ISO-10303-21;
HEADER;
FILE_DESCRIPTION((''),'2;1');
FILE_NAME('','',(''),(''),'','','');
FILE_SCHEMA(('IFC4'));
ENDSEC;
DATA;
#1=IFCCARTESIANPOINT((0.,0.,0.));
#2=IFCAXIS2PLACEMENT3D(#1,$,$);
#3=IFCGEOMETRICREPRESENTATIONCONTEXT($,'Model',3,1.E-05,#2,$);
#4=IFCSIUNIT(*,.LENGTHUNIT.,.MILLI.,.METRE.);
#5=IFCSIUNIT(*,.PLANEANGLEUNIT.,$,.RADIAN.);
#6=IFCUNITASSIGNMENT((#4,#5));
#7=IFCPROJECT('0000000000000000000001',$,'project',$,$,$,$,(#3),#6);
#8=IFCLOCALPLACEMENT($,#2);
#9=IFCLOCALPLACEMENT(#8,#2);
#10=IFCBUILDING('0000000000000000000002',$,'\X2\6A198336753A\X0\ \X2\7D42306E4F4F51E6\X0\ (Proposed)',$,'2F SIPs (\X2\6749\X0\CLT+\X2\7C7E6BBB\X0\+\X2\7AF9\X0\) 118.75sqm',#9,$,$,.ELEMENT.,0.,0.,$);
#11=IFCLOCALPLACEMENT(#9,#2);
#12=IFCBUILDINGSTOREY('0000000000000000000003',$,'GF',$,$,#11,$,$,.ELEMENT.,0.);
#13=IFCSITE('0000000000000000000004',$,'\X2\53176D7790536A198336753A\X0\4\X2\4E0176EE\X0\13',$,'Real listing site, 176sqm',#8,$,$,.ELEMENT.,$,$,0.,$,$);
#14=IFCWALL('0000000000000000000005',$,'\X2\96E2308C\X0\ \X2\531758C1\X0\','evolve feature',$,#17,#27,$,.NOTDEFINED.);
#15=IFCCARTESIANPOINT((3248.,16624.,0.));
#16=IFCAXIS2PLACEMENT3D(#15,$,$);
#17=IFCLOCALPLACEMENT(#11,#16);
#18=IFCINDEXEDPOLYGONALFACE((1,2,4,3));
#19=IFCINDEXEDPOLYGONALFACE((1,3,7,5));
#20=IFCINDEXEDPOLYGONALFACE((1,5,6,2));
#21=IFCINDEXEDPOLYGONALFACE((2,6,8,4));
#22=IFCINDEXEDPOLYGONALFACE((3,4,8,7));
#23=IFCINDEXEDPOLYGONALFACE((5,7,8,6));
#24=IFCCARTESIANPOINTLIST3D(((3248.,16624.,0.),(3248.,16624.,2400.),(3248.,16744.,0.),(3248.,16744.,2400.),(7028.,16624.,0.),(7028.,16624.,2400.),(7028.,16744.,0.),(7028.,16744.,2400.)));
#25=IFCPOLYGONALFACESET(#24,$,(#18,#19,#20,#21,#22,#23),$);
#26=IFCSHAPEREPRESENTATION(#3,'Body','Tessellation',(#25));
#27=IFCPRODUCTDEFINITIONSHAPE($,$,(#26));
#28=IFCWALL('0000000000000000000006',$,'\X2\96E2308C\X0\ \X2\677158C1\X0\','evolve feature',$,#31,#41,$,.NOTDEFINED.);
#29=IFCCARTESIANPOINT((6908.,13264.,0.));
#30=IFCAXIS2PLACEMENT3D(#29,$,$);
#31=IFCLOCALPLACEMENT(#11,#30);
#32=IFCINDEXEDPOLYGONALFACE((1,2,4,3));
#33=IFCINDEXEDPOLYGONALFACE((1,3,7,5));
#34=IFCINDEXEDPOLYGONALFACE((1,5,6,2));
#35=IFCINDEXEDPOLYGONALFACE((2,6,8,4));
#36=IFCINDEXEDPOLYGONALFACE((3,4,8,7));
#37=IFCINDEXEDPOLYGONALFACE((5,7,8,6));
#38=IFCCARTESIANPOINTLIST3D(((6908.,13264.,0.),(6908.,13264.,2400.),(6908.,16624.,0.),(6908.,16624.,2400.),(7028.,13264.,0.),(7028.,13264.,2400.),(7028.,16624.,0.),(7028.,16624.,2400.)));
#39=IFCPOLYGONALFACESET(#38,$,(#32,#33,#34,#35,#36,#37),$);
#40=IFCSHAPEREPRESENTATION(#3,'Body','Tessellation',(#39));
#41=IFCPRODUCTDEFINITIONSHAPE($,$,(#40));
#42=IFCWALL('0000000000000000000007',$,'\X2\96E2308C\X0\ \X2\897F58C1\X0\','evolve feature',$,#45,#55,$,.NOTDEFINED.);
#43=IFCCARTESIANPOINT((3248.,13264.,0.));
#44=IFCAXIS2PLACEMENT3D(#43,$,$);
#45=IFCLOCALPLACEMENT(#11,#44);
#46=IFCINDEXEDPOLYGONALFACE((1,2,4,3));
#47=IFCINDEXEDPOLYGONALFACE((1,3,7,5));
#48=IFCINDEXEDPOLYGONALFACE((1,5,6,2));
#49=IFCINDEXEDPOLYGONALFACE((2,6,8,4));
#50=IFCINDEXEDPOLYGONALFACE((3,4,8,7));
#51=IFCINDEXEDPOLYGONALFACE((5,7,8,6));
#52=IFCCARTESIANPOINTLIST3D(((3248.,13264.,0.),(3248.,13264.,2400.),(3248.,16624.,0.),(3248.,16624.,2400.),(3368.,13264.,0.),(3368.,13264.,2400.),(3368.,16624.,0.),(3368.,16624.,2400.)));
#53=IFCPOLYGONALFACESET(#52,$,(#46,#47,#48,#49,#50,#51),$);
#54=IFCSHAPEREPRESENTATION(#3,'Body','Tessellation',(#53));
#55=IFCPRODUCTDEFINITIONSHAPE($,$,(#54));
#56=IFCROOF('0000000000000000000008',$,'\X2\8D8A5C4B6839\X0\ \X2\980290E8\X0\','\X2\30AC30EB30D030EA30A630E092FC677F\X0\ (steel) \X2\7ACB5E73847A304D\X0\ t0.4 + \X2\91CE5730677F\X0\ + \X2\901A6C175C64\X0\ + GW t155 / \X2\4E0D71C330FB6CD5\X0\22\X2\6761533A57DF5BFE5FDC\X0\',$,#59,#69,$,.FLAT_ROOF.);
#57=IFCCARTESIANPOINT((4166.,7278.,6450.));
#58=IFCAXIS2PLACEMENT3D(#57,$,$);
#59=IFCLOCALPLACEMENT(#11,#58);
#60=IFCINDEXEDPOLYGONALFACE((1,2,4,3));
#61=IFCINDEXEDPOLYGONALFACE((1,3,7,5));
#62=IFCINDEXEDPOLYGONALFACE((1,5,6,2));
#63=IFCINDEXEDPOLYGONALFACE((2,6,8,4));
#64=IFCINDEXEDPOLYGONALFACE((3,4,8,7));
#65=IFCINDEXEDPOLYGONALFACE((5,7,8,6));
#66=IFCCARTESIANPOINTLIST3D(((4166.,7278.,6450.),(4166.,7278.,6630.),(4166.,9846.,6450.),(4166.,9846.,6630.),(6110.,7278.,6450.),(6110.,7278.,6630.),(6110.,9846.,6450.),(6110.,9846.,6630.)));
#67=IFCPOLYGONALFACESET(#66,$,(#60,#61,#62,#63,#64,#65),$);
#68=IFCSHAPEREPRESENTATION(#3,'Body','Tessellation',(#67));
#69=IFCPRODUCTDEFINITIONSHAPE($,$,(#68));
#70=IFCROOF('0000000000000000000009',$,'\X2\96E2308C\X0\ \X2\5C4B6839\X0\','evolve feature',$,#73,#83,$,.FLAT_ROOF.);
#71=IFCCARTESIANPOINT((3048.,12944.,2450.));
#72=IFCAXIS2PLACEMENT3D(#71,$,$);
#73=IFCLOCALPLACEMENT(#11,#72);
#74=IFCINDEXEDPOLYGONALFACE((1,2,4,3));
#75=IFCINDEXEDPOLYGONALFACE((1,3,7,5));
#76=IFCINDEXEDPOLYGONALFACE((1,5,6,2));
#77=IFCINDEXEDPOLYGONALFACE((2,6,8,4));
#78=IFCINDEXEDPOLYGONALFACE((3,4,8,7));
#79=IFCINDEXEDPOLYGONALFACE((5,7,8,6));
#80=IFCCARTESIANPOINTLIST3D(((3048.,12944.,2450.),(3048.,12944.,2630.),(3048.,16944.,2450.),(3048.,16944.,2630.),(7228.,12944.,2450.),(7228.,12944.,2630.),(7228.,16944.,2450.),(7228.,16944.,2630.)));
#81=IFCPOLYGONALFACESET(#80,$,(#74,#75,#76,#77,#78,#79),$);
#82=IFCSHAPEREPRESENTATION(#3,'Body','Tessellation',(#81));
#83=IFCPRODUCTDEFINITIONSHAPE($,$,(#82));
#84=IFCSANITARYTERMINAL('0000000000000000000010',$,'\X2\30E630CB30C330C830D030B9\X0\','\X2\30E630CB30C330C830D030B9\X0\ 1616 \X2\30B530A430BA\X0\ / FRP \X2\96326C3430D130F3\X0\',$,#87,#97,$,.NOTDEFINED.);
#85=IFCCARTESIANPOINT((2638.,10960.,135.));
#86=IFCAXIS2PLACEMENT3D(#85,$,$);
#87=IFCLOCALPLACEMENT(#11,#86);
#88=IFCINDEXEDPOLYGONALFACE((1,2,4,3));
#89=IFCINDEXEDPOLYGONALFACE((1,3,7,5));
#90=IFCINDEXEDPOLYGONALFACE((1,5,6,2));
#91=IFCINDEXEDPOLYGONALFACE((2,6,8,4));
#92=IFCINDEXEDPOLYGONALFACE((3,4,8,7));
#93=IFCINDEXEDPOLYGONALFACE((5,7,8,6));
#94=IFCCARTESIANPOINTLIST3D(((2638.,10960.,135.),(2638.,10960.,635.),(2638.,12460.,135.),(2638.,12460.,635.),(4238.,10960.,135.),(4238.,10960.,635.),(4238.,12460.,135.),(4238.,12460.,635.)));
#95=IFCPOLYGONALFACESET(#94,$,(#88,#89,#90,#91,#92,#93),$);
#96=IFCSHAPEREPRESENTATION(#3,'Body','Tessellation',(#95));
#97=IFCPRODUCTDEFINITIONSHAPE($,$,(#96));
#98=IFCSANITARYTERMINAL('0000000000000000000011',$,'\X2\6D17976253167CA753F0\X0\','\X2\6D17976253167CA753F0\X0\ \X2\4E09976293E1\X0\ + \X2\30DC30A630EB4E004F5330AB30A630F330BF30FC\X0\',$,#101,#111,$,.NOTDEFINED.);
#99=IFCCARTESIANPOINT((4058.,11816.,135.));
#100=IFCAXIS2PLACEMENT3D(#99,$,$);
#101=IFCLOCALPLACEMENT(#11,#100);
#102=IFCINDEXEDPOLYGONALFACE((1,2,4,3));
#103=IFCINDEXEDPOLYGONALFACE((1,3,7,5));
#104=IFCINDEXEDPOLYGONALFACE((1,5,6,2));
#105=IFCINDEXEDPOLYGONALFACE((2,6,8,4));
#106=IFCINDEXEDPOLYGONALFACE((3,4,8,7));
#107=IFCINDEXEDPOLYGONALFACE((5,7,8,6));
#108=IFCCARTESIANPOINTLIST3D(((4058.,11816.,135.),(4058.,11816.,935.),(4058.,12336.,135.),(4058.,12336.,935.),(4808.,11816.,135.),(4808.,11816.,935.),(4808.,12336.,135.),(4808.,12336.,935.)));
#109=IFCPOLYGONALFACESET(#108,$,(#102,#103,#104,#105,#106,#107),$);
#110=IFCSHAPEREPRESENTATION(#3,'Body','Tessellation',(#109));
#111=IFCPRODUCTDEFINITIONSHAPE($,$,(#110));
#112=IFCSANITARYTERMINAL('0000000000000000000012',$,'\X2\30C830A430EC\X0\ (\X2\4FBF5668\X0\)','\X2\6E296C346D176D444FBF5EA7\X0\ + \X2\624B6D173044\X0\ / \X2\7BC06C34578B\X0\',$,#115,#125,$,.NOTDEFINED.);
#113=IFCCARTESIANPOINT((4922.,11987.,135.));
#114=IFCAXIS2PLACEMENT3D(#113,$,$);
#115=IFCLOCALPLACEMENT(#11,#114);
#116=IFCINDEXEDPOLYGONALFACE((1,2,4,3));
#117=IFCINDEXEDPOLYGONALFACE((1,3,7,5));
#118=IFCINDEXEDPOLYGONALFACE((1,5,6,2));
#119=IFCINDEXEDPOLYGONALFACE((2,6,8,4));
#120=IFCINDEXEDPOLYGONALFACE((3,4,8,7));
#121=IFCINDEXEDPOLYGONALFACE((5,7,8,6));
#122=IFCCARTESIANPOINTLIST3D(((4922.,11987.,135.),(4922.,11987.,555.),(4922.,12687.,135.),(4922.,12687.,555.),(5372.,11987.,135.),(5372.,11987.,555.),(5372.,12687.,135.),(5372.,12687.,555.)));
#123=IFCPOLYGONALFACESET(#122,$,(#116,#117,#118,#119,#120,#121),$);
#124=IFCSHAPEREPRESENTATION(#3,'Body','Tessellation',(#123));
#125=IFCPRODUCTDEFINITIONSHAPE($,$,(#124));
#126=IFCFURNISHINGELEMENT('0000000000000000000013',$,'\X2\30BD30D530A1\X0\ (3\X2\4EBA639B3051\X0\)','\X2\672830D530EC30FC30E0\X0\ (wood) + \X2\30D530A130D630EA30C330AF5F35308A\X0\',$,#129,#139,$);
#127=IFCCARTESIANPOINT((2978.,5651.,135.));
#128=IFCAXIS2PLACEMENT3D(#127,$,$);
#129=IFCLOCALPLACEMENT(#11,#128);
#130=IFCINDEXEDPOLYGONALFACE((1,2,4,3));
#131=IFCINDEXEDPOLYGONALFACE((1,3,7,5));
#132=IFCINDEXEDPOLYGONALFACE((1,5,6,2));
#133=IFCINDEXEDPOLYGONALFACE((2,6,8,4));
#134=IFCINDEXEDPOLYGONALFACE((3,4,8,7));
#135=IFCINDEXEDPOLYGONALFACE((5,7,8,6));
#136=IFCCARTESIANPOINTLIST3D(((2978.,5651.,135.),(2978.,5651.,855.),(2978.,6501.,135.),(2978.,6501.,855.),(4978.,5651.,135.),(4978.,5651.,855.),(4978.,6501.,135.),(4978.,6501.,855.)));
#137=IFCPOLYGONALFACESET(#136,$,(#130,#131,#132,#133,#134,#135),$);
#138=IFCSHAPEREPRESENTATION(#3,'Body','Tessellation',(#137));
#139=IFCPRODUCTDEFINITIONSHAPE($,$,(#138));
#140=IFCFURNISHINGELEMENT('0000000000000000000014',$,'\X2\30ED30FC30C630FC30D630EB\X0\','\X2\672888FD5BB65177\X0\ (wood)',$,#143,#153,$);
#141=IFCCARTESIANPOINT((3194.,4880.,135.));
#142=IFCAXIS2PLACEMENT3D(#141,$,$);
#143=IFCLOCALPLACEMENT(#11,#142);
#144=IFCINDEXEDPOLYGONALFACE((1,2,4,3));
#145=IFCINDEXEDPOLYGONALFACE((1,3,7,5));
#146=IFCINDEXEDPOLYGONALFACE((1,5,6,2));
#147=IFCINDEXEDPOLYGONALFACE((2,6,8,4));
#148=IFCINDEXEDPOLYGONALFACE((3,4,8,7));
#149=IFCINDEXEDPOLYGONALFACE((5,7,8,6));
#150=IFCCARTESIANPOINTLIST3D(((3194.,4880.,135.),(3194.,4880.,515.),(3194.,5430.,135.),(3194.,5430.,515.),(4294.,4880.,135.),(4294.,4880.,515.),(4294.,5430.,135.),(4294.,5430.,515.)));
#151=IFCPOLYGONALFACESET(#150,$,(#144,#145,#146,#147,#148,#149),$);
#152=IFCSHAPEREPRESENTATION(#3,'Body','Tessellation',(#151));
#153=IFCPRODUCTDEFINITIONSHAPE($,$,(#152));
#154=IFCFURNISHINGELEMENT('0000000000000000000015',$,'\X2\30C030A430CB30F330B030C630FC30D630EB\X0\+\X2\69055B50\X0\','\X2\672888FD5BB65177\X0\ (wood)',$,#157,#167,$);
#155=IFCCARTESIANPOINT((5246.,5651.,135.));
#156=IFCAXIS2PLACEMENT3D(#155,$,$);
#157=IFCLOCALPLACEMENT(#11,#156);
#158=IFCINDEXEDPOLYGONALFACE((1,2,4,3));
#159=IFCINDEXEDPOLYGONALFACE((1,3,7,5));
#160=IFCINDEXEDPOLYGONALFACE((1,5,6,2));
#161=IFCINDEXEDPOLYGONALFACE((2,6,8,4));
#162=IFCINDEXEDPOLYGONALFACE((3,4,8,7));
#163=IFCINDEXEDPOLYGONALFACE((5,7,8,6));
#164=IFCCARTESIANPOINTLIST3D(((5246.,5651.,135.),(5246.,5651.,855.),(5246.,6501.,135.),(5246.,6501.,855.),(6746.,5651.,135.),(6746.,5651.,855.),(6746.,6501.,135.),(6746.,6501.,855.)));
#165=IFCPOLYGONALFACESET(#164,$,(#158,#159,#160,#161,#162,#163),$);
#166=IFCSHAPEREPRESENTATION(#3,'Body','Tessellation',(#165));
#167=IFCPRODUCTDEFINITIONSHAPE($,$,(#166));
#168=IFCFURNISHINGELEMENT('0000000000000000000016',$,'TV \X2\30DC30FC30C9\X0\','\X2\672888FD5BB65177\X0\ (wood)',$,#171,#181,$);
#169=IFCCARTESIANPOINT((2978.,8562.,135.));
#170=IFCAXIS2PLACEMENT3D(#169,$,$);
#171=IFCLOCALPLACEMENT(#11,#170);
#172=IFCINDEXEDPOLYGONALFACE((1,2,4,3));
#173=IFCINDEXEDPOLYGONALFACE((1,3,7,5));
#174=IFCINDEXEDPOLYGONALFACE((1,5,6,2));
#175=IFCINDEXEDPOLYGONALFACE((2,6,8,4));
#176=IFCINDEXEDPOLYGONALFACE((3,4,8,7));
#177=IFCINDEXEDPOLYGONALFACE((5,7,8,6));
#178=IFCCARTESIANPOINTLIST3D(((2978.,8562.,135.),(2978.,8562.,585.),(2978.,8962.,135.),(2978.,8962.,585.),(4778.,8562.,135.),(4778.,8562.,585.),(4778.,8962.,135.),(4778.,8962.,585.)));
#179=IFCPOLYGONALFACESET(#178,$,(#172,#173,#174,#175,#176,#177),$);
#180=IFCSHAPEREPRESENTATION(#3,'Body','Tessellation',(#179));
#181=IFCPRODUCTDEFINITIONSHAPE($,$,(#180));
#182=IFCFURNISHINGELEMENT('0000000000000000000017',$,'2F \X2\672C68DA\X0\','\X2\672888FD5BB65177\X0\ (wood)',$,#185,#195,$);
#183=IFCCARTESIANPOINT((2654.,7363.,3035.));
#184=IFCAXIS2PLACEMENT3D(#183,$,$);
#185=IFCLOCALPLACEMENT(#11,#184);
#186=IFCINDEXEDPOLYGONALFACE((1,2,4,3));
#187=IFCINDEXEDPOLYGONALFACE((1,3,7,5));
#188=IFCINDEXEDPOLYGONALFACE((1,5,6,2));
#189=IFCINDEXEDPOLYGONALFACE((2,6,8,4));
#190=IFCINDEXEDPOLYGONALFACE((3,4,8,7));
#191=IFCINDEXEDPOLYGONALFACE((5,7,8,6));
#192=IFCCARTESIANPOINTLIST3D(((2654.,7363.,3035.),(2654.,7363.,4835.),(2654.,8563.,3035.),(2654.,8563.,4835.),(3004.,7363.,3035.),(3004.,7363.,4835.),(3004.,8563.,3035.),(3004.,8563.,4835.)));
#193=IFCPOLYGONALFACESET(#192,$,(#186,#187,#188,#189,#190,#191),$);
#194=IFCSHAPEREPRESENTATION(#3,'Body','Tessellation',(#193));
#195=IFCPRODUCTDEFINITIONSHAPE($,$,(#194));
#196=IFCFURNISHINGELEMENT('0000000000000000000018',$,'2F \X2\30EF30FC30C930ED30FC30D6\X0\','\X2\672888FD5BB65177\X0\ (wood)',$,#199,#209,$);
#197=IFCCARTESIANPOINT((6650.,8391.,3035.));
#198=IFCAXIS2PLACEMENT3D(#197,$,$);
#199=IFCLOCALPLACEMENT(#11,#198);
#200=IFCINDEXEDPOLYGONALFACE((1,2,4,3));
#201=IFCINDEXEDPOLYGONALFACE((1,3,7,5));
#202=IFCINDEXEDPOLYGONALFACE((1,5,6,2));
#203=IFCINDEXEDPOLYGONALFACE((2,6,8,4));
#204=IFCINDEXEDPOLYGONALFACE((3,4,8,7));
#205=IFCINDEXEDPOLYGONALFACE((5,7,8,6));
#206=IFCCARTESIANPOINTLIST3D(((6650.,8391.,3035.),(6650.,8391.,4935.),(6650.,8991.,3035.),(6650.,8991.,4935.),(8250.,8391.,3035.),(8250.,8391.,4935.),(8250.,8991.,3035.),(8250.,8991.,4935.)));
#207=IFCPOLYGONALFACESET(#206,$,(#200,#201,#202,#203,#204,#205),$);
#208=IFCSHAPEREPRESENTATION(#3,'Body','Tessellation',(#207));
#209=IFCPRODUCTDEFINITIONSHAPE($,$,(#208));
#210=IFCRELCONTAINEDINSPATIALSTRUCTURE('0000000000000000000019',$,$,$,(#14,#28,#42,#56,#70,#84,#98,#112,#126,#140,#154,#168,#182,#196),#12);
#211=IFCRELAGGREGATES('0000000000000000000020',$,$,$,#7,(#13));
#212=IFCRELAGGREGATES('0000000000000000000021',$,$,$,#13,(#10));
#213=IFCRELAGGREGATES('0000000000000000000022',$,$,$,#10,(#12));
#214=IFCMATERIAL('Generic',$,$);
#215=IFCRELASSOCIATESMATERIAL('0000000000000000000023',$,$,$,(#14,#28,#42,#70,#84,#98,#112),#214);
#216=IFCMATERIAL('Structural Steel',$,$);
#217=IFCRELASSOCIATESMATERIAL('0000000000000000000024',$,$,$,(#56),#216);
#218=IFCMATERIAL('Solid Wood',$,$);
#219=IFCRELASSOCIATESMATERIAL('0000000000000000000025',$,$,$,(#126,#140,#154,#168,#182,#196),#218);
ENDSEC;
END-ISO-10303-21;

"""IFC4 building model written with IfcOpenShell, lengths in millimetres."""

from ifc_helpers import new_model, si_unit, frame, frame_2d, origin, place, context, project, spatial, rectangle, extrude, material, element, save


model = new_model("IFC4")

# Units and contexts
model_context = context("Model", 3, precision=1e-05, world=origin())
ifc_project = project(units=[si_unit("LENGTHUNIT", "METRE", prefix="MILLI"), si_unit("PLANEANGLEUNIT", "RADIAN")], contexts=[model_context])

# Site, building, storey
site_placement = place(None, origin())
site = spatial("IfcSite", under=ifc_project, at=site_placement, Name="北海道標茶町4丁目13", ObjectType="Real listing site, 176sqm", CompositionType="ELEMENT", RefElevation=0.0)
building_placement = place(site_placement, origin())
building = spatial("IfcBuilding", under=site, at=building_placement, Name="標茶町 終の住処 (Proposed)", ObjectType="2F SIPs (杉CLT+籾殻+竹) 118.75sqm", CompositionType="ELEMENT", ElevationOfRefHeight=0.0, ElevationOfTerrain=0.0)
storey_placement = place(building_placement, origin())
storey = spatial("IfcBuildingStorey", under=building, at=storey_placement, Name="GF", CompositionType="ELEMENT", Elevation=0.0)

# Shared definitions
ifc_material_1 = material(Name="Generic")

# Shared definitions
ifc_material_2 = material(Name="Solid Wood")

# Walls
wall_1_placement = place(storey_placement, frame((3248.0, 16624.0, 0.0)))
element("IfcWall", 1, at=wall_1_placement, inside=storey, material=ifc_material_1, Name="離れ 北壁", Description="evolve feature", PredefinedType="NOTDEFINED", context=model_context, shape_type="SweptSolid", body=[
    extrude(rectangle(XDim=3780.0, YDim=120.0, at=frame_2d((1890.0, 60.0))), frame((3248.0, 16624.0, 0.0)), (0.0, 0.0, 1.0), 2400.0),
])
wall_2_placement = place(storey_placement, frame((6908.0, 13264.0, 0.0)))
element("IfcWall", 2, at=wall_2_placement, inside=storey, material=ifc_material_1, Name="離れ 東壁", Description="evolve feature", PredefinedType="NOTDEFINED", context=model_context, shape_type="SweptSolid", body=[
    extrude(rectangle(XDim=120.0, YDim=3360.0, at=frame_2d((60.0, 1680.0))), frame((6908.0, 13264.0, 0.0)), (0.0, 0.0, 1.0), 2400.0),
])
wall_3_placement = place(storey_placement, frame((3248.0, 13264.0, 0.0)))
element("IfcWall", 3, at=wall_3_placement, inside=storey, material=ifc_material_1, Name="離れ 西壁", Description="evolve feature", PredefinedType="NOTDEFINED", context=model_context, shape_type="SweptSolid", body=[
    extrude(rectangle(XDim=120.0, YDim=3360.0, at=frame_2d((60.0, 1680.0))), frame((3248.0, 13264.0, 0.0)), (0.0, 0.0, 1.0), 2400.0),
])

# Roofs
ifc_material_3 = material(Name="Structural Steel")
roof_1_placement = place(storey_placement, frame((4166.0, 7278.0, 6450.0)))
element("IfcRoof", 4, at=roof_1_placement, inside=storey, material=ifc_material_3, Name="越屋根 頂部", Description="ガルバリウム鋼板 (steel) 立平葺き t0.4 + 野地板 + 通気層 + GW t155 / 不燃・法22条区域対応", PredefinedType="FLAT_ROOF", context=model_context, shape_type="SweptSolid", body=[
    extrude(rectangle(XDim=1944.0, YDim=2568.0, at=frame_2d((972.0, 1284.0))), frame((4166.0, 7278.0, 6450.0)), (0.0, 0.0, 1.0), 180.0),
])
roof_2_placement = place(storey_placement, frame((3048.0, 12944.0, 2450.0)))
element("IfcRoof", 5, at=roof_2_placement, inside=storey, material=ifc_material_1, Name="離れ 屋根", Description="evolve feature", PredefinedType="FLAT_ROOF", context=model_context, shape_type="SweptSolid", body=[
    extrude(rectangle(XDim=4180.0, YDim=4000.0, at=frame_2d((2090.0, 2000.0))), frame((3048.0, 12944.0, 2450.0)), (0.0, 0.0, 1.0), 180.0),
])

# Sanitary terminals
sanitary_terminal_1_placement = place(storey_placement, frame((2638.0, 10960.0, 135.0)))
element("IfcSanitaryTerminal", 6, at=sanitary_terminal_1_placement, inside=storey, material=ifc_material_1, Name="ユニットバス", Description="ユニットバス 1616 サイズ / FRP 防水パン", PredefinedType="NOTDEFINED", context=model_context, shape_type="SweptSolid", body=[
    extrude(rectangle(XDim=1600.0, YDim=1500.0, at=frame_2d((800.0, 750.0))), frame((2638.0, 10960.0, 135.0)), (0.0, 0.0, 1.0), 500.0),
])
sanitary_terminal_2_placement = place(storey_placement, frame((4058.0, 11816.0, 135.0)))
element("IfcSanitaryTerminal", 7, at=sanitary_terminal_2_placement, inside=storey, material=ifc_material_1, Name="洗面化粧台", Description="洗面化粧台 三面鏡 + ボウル一体カウンター", PredefinedType="NOTDEFINED", context=model_context, shape_type="SweptSolid", body=[
    extrude(rectangle(XDim=750.0, YDim=520.0, at=frame_2d((375.0, 260.0))), frame((4058.0, 11816.0, 135.0)), (0.0, 0.0, 1.0), 800.0),
])
sanitary_terminal_3_placement = place(storey_placement, frame((4922.0, 11987.0, 135.0)))
element("IfcSanitaryTerminal", 8, at=sanitary_terminal_3_placement, inside=storey, material=ifc_material_1, Name="トイレ (便器)", Description="温水洗浄便座 + 手洗い / 節水型", PredefinedType="NOTDEFINED", context=model_context, shape_type="SweptSolid", body=[
    extrude(rectangle(XDim=450.0, YDim=700.0, at=frame_2d((225.0, 350.0))), frame((4922.0, 11987.0, 135.0)), (0.0, 0.0, 1.0), 420.0),
])

# Furnishing elements
furnishing_1_placement = place(storey_placement, frame((2978.0, 5651.0, 135.0)))
element("IfcFurnishingElement", 9, at=furnishing_1_placement, inside=storey, material=ifc_material_2, Name="ソファ (3人掛け)", Description="木フレーム (wood) + ファブリック張り", context=model_context, shape_type="SweptSolid", body=[
    extrude(rectangle(XDim=2000.0, YDim=850.0, at=frame_2d((1000.0, 425.0))), frame((2978.0, 5651.0, 135.0)), (0.0, 0.0, 1.0), 720.0),
])
furnishing_2_placement = place(storey_placement, frame((3194.0, 4880.0, 135.0)))
element("IfcFurnishingElement", 10, at=furnishing_2_placement, inside=storey, material=ifc_material_2, Name="ローテーブル", Description="木製家具 (wood)", context=model_context, shape_type="SweptSolid", body=[
    extrude(rectangle(XDim=1100.0, YDim=550.0, at=frame_2d((550.0, 275.0))), frame((3194.0, 4880.0, 135.0)), (0.0, 0.0, 1.0), 380.0),
])
furnishing_3_placement = place(storey_placement, frame((5246.0, 5651.0, 135.0)))
element("IfcFurnishingElement", 11, at=furnishing_3_placement, inside=storey, material=ifc_material_2, Name="ダイニングテーブル+椅子", Description="木製家具 (wood)", context=model_context, shape_type="SweptSolid", body=[
    extrude(rectangle(XDim=1500.0, YDim=850.0, at=frame_2d((750.0, 425.0))), frame((5246.0, 5651.0, 135.0)), (0.0, 0.0, 1.0), 720.0),
])
furnishing_4_placement = place(storey_placement, frame((2978.0, 8562.0, 135.0)))
element("IfcFurnishingElement", 12, at=furnishing_4_placement, inside=storey, material=ifc_material_2, Name="TV ボード", Description="木製家具 (wood)", context=model_context, shape_type="SweptSolid", body=[
    extrude(rectangle(XDim=1800.0, YDim=400.0, at=frame_2d((900.0, 200.0))), frame((2978.0, 8562.0, 135.0)), (0.0, 0.0, 1.0), 450.0),
])
furnishing_5_placement = place(storey_placement, frame((2654.0, 7363.0, 3035.0)))
element("IfcFurnishingElement", 13, at=furnishing_5_placement, inside=storey, material=ifc_material_2, Name="2F 本棚", Description="木製家具 (wood)", context=model_context, shape_type="SweptSolid", body=[
    extrude(rectangle(XDim=350.0, YDim=1200.0, at=frame_2d((175.0, 600.0))), frame((2654.0, 7363.0, 3035.0)), (0.0, 0.0, 1.0), 1800.0),
])
furnishing_6_placement = place(storey_placement, frame((6650.0, 8391.0, 3035.0)))
element("IfcFurnishingElement", 14, at=furnishing_6_placement, inside=storey, material=ifc_material_2, Name="2F ワードローブ", Description="木製家具 (wood)", context=model_context, shape_type="SweptSolid", body=[
    extrude(rectangle(XDim=1600.0, YDim=600.0, at=frame_2d((800.0, 300.0))), frame((6650.0, 8391.0, 3035.0)), (0.0, 0.0, 1.0), 1900.0),
])

save(model, "model.ifc")
